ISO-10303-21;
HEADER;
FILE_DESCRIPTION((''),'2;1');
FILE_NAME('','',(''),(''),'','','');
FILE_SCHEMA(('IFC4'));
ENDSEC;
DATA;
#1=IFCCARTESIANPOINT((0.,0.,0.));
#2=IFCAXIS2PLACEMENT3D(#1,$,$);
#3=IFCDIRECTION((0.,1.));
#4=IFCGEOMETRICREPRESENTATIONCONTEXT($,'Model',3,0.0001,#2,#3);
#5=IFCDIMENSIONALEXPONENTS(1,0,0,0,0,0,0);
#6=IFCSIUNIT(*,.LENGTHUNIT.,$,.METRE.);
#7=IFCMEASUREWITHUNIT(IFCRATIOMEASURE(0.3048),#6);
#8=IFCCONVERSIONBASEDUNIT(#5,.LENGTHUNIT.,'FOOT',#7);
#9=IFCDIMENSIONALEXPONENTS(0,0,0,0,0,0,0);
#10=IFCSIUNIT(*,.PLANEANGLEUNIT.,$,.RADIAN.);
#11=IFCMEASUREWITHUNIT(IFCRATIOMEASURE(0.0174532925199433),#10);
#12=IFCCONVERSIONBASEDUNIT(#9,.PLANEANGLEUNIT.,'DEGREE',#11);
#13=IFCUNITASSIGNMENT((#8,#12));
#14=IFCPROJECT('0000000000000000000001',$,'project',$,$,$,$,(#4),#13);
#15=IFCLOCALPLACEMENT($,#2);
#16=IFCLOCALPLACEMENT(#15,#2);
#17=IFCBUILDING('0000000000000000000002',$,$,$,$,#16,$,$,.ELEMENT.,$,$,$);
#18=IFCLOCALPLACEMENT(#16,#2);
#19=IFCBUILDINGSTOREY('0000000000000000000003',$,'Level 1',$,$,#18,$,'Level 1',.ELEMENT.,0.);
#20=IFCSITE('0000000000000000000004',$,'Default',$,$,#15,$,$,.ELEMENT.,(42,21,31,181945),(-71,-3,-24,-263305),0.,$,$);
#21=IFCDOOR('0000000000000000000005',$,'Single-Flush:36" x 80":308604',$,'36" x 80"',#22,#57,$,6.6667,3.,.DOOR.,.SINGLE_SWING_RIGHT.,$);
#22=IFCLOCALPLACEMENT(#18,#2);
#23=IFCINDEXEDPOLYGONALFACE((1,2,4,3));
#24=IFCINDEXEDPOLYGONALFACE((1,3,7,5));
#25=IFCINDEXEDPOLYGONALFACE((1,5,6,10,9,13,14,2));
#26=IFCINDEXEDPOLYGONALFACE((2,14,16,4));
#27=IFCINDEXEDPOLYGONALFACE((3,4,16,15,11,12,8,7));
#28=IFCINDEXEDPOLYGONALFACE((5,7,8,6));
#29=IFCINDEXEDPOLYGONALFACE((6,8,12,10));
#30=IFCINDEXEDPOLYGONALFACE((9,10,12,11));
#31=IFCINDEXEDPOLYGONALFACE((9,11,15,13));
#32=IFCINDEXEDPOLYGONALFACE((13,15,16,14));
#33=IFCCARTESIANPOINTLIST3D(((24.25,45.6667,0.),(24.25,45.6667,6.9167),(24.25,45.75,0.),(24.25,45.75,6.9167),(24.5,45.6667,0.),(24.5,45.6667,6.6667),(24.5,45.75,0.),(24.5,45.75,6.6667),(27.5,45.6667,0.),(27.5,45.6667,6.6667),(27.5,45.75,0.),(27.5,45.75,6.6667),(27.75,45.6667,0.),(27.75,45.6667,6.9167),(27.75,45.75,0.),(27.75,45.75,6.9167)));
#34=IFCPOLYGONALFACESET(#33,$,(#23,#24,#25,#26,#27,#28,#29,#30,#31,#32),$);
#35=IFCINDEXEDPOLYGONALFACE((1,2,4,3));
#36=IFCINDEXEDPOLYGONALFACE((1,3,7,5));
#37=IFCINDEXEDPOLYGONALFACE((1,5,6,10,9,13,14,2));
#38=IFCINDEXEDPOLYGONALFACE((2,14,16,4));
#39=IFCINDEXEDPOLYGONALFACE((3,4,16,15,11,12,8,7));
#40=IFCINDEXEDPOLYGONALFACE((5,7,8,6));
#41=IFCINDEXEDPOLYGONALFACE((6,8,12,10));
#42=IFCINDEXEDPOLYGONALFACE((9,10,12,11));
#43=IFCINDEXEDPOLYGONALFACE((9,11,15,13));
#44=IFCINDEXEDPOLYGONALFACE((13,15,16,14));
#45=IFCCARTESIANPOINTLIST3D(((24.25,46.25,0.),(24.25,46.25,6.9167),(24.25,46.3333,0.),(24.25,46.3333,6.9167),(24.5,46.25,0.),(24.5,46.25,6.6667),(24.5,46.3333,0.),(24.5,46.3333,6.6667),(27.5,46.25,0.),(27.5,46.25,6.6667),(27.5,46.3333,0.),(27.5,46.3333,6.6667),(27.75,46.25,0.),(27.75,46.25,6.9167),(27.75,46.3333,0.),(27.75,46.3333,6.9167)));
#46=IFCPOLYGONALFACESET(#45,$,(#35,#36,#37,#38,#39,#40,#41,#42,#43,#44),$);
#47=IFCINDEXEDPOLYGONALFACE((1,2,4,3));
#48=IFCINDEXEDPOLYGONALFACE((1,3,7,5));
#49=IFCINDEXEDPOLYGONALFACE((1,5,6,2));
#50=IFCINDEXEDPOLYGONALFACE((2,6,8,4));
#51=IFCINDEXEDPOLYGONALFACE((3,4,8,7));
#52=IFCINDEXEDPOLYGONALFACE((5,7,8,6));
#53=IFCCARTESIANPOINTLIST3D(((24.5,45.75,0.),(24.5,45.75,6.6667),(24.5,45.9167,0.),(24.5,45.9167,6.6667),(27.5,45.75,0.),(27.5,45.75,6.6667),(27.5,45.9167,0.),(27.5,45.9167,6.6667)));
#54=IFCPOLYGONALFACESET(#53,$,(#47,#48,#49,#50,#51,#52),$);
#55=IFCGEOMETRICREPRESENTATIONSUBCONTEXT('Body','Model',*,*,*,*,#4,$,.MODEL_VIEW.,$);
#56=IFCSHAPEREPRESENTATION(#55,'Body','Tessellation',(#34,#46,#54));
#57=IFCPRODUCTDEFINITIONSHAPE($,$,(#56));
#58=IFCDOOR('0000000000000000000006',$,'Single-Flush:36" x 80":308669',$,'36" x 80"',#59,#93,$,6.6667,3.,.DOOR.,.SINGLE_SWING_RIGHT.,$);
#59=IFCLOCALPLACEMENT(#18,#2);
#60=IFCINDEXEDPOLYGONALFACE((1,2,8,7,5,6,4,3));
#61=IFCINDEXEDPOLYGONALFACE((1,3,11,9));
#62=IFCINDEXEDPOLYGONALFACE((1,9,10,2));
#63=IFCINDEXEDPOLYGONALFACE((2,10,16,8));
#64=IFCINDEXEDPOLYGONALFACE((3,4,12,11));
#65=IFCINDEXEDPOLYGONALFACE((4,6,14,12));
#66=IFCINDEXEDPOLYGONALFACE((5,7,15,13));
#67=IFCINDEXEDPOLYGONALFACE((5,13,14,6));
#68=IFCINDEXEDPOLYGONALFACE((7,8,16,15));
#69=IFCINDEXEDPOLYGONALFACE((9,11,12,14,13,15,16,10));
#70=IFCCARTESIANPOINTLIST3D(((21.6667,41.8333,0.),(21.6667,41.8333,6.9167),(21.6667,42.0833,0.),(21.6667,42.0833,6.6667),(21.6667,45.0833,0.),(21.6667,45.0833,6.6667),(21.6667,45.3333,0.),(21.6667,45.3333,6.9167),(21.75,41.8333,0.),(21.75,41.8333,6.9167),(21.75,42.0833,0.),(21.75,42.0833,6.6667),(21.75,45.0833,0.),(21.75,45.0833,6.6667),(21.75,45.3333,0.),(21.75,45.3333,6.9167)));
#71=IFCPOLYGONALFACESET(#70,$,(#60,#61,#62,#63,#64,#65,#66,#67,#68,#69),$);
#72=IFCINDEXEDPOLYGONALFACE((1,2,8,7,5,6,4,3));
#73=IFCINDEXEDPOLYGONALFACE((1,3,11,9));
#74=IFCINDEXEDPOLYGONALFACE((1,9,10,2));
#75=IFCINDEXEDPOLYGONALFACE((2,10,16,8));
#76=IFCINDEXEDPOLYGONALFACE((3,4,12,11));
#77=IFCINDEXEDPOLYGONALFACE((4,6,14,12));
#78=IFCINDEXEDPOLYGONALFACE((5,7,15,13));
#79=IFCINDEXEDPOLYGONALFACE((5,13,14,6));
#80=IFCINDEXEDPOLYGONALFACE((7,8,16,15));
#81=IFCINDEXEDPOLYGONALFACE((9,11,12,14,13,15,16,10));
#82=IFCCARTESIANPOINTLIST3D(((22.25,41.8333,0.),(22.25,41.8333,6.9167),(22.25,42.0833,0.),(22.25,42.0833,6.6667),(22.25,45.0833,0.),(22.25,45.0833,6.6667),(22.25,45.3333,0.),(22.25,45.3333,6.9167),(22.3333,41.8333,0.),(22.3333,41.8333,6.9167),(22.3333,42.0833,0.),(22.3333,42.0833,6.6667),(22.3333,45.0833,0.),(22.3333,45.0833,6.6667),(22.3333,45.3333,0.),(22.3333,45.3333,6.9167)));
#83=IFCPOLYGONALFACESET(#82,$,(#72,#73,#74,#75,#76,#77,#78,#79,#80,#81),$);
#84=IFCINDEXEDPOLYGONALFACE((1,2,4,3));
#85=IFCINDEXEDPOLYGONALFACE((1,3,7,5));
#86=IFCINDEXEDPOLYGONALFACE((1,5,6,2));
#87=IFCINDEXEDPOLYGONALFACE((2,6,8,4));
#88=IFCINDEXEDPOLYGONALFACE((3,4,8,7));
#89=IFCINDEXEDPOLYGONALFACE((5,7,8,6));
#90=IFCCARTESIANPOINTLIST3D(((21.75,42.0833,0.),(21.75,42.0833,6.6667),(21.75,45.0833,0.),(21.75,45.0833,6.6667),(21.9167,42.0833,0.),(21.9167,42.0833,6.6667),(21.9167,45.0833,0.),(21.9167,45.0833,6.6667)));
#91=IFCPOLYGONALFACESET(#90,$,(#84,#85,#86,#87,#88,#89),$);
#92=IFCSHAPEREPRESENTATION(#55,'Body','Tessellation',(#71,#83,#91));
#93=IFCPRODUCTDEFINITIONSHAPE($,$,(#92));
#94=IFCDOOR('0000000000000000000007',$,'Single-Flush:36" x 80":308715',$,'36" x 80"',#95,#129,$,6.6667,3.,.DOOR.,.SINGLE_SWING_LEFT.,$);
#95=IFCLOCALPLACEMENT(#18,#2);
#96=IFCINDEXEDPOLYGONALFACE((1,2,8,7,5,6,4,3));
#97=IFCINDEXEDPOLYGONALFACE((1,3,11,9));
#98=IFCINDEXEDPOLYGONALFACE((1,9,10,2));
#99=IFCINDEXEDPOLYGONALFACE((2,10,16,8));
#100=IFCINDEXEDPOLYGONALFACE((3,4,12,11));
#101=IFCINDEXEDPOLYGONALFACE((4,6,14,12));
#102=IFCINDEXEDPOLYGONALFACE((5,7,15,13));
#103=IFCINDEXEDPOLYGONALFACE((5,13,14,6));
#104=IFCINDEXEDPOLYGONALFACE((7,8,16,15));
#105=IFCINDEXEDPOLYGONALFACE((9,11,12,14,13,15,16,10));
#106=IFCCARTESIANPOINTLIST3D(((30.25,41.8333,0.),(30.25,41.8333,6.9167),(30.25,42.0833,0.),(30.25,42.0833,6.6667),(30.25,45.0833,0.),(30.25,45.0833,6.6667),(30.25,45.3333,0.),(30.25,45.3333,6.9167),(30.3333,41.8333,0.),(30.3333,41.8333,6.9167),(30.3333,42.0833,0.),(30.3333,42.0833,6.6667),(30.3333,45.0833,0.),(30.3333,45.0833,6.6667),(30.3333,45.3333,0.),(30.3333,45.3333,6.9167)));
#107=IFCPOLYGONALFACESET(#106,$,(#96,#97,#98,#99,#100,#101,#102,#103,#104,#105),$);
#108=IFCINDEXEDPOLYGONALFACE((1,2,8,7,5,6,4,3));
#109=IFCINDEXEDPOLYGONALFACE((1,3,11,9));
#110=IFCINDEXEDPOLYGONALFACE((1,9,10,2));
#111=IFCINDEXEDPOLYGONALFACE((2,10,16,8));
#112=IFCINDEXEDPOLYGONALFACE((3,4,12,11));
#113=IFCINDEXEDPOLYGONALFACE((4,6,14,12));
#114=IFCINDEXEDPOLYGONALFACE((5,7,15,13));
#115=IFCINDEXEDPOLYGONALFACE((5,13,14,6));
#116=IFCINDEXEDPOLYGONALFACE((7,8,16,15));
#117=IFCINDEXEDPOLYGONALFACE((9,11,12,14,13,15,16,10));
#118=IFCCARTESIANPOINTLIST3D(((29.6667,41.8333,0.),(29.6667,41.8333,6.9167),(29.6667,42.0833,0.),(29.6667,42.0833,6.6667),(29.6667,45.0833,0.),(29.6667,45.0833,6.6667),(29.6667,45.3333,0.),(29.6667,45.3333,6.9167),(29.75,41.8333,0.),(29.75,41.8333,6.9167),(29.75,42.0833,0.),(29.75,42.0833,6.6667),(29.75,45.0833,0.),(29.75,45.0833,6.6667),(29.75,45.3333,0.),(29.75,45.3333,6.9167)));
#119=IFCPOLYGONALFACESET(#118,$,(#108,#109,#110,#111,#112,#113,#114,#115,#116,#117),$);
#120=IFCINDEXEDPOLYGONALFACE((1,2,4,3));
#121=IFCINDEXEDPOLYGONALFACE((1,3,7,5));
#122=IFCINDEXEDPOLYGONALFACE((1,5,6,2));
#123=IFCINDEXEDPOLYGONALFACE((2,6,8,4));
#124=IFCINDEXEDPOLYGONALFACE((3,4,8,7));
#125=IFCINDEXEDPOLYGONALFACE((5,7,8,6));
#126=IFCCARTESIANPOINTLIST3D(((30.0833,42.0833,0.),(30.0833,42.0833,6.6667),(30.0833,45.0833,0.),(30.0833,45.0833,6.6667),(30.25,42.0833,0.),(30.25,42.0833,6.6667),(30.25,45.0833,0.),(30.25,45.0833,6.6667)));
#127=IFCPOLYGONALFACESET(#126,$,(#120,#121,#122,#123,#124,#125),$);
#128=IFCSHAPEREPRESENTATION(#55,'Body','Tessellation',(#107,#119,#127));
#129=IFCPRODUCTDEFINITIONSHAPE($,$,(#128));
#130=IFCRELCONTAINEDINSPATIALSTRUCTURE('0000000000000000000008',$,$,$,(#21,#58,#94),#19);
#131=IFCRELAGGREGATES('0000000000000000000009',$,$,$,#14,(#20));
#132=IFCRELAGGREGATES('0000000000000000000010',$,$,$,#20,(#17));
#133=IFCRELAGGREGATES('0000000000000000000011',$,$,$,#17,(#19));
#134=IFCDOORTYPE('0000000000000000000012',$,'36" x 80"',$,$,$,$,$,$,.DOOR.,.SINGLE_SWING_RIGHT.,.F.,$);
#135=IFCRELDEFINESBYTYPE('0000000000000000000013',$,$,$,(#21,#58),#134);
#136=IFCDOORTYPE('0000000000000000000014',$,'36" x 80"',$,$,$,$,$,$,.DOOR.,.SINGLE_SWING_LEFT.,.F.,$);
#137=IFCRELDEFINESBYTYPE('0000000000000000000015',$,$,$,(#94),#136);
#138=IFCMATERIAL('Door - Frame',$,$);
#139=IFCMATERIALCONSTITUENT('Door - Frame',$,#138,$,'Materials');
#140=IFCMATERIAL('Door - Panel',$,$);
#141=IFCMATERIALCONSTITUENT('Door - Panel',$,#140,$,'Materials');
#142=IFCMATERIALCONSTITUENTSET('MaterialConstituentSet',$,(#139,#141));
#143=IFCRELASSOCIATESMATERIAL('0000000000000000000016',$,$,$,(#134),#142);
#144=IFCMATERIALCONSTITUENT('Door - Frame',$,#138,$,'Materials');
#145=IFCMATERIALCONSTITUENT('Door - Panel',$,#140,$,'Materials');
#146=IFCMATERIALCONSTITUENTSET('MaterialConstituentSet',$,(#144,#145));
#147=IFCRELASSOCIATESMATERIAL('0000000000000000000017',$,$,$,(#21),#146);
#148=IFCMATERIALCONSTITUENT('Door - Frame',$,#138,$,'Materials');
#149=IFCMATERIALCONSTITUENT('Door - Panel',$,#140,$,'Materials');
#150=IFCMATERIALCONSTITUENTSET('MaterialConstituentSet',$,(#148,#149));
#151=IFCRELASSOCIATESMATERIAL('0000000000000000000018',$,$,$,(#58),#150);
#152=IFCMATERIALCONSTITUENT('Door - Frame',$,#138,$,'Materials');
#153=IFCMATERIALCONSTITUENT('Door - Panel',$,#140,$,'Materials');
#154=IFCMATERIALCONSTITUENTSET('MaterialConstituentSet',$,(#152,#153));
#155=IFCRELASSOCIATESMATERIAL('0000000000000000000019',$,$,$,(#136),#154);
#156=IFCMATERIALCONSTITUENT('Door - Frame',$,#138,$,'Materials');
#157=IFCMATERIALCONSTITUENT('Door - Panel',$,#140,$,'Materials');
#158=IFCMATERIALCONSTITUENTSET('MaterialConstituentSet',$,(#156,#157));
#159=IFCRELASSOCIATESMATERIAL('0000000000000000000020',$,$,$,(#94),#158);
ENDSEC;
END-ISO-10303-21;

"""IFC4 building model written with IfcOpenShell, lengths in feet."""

from ifc_helpers import new_model, entity, si_unit, converted_unit, direction, frame, origin, origin_2d_with_axis, place, context, subcontext, project, spatial, polyline, rectangle, outline, extrude, source, transform, mapped, material, constituent, constituent_set, type_object, type_shapes, element, save


model = new_model("IFC4")

# Units and contexts
model_context = context("Model", 3, precision=0.0001, world=origin(), true_north=direction((0.0, 1.0)))
body_context = subcontext(model_context, "Body", "Model", "MODEL_VIEW")
ifc_project = project(units=[converted_unit("LENGTHUNIT", "FOOT", entity("IfcRatioMeasure", 0.3048), si_unit("LENGTHUNIT", "METRE"), dimensions=[1, 0, 0, 0, 0, 0, 0]), converted_unit("PLANEANGLEUNIT", "DEGREE", entity("IfcRatioMeasure", 0.0174532925199433), si_unit("PLANEANGLEUNIT", "RADIAN"), dimensions=[0, 0, 0, 0, 0, 0, 0])], contexts=[model_context])

# Site, building, storey
site_placement = place(None, origin())
site = spatial("IfcSite", under=ifc_project, at=site_placement, Name="Default", CompositionType="ELEMENT", RefLatitude=(42, 21, 31, 181945), RefLongitude=(-71, -3, -24, -263305), RefElevation=0.0)
building_placement = place(site_placement, origin())
building = spatial("IfcBuilding", under=site, at=building_placement, CompositionType="ELEMENT")
storey_placement = place(building_placement, origin())
storey = spatial("IfcBuildingStorey", under=building, at=storey_placement, Name="Level 1", LongName="Level 1", CompositionType="ELEMENT", Elevation=0.0)

# Shared definitions
placement_1 = place(storey_placement, frame((-0.25, 46.0, 0.0)))
placement_2 = place(storey_placement, frame((30.0, 45.75, 0.0), z_axis=(0.0, 0.0, 1.0), x_axis=(0.0, -1.0, 0.0)))
placement_3 = place(storey_placement, frame((22.0, 45.75, 0.0), z_axis=(0.0, 0.0, 1.0), x_axis=(0.0, -1.0, 0.0)))

# Doors
ifc_material_1 = material(Name="Door - Frame")
ifc_constituent_1 = constituent(ifc_material_1, Name="Door - Frame", Category="Materials")
ifc_material_2 = material(Name="Door - Panel")
ifc_constituent_2 = constituent(ifc_material_2, Name="Door - Panel", Category="Materials")
ifc_constituent_set_1 = constituent_set(constituents=[ifc_constituent_1, ifc_constituent_2], Name="MaterialConstituentSet")
ifc_constituent_3 = constituent(ifc_material_1, Name="Door - Frame", Category="Materials")
ifc_constituent_4 = constituent(ifc_material_2, Name="Door - Panel", Category="Materials")
ifc_constituent_set_2 = constituent_set(constituents=[ifc_constituent_3, ifc_constituent_4], Name="MaterialConstituentSet")
door_type_1 = type_object("IfcDoorType", Name="36\" x 80\"", OperationType="SINGLE_SWING_RIGHT", ParameterTakesPrecedence=False, PredefinedType="DOOR", material=ifc_constituent_set_2)
shared_shape_1 = source(origin(), body_context, "Body", "SweptSolid", [
    extrude(outline(polyline([(-1.75, -3.5208), (1.75, -3.5208), (1.75, 3.3958), (1.5, 3.3958), (1.5, -3.2708), (-1.5, -3.2708), (-1.5, 3.3958), (-1.75, 3.3958), (-1.75, -3.5208)])), frame((1.5, 0.5, 3.3958), z_axis=(0.0, 1.0, 0.0), x_axis=(1.0, 0.0, 0.0)), (0.0, 0.0, 1.0), 0.0833),
    extrude(outline(polyline([(-3.5208, -1.75), (3.3958, -1.75), (3.3958, -1.5), (-3.2708, -1.5), (-3.2708, 1.5), (3.3958, 1.5), (3.3958, 1.75), (-3.5208, 1.75), (-3.5208, -1.75)])), frame((1.5, -0.0833, 3.3958), z_axis=(0.0, 1.0, 0.0), x_axis=(0.0, 0.0, -1.0)), (0.0, 0.0, 1.0), 0.0833),
    extrude(rectangle(XDim=0.1667, YDim=3.0, at=origin_2d_with_axis()), frame((1.5, 0.4167, 0.0), z_axis=(0.0, 0.0, 1.0), x_axis=(0.0, 1.0, 0.0)), (0.0, 0.0, 1.0), 6.6667),
])
type_shapes(door_type_1, [shared_shape_1])
placement_4 = place(placement_1, frame((27.75, 0.25, 0.0)))
door_1_placement = place(placement_4, frame((0.0, 0.0, 0.0), z_axis=(0.0, 0.0, 1.0), x_axis=(-1.0, 0.0, 0.0)))
element("IfcDoor", 1, at=door_1_placement, inside=storey, type_object=door_type_1, material=ifc_constituent_set_1, Name="Single-Flush:36\" x 80\":308604", ObjectType="36\" x 80\"", OperationType="SINGLE_SWING_RIGHT", OverallHeight=6.6667, OverallWidth=3.0, PredefinedType="DOOR", context=body_context, shape_type="MappedRepresentation", body=[
    mapped(shared_shape_1, transform((0.0, 0.0, 0.0), scale=1.0)),
])
ifc_constituent_5 = constituent(ifc_material_1, Name="Door - Frame", Category="Materials")
ifc_constituent_6 = constituent(ifc_material_2, Name="Door - Panel", Category="Materials")
ifc_constituent_set_3 = constituent_set(constituents=[ifc_constituent_5, ifc_constituent_6], Name="MaterialConstituentSet")
placement_5 = place(placement_3, frame((3.6667, 0.25, 0.0)))
door_2_placement = place(placement_5, frame((0.0, 0.0, 0.0), z_axis=(0.0, 0.0, 1.0), x_axis=(-1.0, 0.0, 0.0)))
element("IfcDoor", 2, at=door_2_placement, inside=storey, type_object=door_type_1, material=ifc_constituent_set_3, Name="Single-Flush:36\" x 80\":308669", ObjectType="36\" x 80\"", OperationType="SINGLE_SWING_RIGHT", OverallHeight=6.6667, OverallWidth=3.0, PredefinedType="DOOR", context=body_context, shape_type="MappedRepresentation", body=[
    mapped(shared_shape_1, transform((0.0, 0.0, 0.0), scale=1.0)),
])
ifc_constituent_7 = constituent(ifc_material_1, Name="Door - Frame", Category="Materials")
ifc_constituent_8 = constituent(ifc_material_2, Name="Door - Panel", Category="Materials")
ifc_constituent_set_4 = constituent_set(constituents=[ifc_constituent_7, ifc_constituent_8], Name="MaterialConstituentSet")
ifc_constituent_9 = constituent(ifc_material_1, Name="Door - Frame", Category="Materials")
ifc_constituent_10 = constituent(ifc_material_2, Name="Door - Panel", Category="Materials")
ifc_constituent_set_5 = constituent_set(constituents=[ifc_constituent_9, ifc_constituent_10], Name="MaterialConstituentSet")
door_type_2 = type_object("IfcDoorType", Name="36\" x 80\"", OperationType="SINGLE_SWING_LEFT", ParameterTakesPrecedence=False, PredefinedType="DOOR", material=ifc_constituent_set_5)
shared_shape_2 = source(origin(), body_context, "Body", "SweptSolid", [
    extrude(outline(polyline([(-1.75, -3.5208), (1.75, -3.5208), (1.75, 3.3958), (1.5, 3.3958), (1.5, -3.2708), (-1.5, -3.2708), (-1.5, 3.3958), (-1.75, 3.3958), (-1.75, -3.5208)])), frame((1.5, 0.5833, 3.3958), z_axis=(0.0, -1.0, 0.0), x_axis=(-1.0, 0.0, 0.0)), (0.0, 0.0, 1.0), 0.0833),
    extrude(outline(polyline([(-3.5208, -1.75), (3.3958, -1.75), (3.3958, -1.5), (-3.2708, -1.5), (-3.2708, 1.5), (3.3958, 1.5), (3.3958, 1.75), (-3.5208, 1.75), (-3.5208, -1.75)])), frame((1.5, 0.0, 3.3958), z_axis=(0.0, -1.0, 0.0), x_axis=(0.0, 0.0, -1.0)), (0.0, 0.0, 1.0), 0.0833),
    extrude(rectangle(XDim=3.0, YDim=0.1667, at=origin_2d_with_axis()), frame((1.5, 0.4167, 0.0)), (0.0, 0.0, 1.0), 6.6667),
])
type_shapes(door_type_2, [shared_shape_2])
placement_6 = place(placement_2, frame((0.6667, -0.25, 0.0)))
door_3_placement = place(placement_6, origin())
element("IfcDoor", 3, at=door_3_placement, inside=storey, type_object=door_type_2, material=ifc_constituent_set_4, Name="Single-Flush:36\" x 80\":308715", ObjectType="36\" x 80\"", OperationType="SINGLE_SWING_LEFT", OverallHeight=6.6667, OverallWidth=3.0, PredefinedType="DOOR", context=body_context, shape_type="MappedRepresentation", body=[
    mapped(shared_shape_2, transform((0.0, 0.0, 0.0), scale=1.0)),
])

save(model, "model.ifc")
